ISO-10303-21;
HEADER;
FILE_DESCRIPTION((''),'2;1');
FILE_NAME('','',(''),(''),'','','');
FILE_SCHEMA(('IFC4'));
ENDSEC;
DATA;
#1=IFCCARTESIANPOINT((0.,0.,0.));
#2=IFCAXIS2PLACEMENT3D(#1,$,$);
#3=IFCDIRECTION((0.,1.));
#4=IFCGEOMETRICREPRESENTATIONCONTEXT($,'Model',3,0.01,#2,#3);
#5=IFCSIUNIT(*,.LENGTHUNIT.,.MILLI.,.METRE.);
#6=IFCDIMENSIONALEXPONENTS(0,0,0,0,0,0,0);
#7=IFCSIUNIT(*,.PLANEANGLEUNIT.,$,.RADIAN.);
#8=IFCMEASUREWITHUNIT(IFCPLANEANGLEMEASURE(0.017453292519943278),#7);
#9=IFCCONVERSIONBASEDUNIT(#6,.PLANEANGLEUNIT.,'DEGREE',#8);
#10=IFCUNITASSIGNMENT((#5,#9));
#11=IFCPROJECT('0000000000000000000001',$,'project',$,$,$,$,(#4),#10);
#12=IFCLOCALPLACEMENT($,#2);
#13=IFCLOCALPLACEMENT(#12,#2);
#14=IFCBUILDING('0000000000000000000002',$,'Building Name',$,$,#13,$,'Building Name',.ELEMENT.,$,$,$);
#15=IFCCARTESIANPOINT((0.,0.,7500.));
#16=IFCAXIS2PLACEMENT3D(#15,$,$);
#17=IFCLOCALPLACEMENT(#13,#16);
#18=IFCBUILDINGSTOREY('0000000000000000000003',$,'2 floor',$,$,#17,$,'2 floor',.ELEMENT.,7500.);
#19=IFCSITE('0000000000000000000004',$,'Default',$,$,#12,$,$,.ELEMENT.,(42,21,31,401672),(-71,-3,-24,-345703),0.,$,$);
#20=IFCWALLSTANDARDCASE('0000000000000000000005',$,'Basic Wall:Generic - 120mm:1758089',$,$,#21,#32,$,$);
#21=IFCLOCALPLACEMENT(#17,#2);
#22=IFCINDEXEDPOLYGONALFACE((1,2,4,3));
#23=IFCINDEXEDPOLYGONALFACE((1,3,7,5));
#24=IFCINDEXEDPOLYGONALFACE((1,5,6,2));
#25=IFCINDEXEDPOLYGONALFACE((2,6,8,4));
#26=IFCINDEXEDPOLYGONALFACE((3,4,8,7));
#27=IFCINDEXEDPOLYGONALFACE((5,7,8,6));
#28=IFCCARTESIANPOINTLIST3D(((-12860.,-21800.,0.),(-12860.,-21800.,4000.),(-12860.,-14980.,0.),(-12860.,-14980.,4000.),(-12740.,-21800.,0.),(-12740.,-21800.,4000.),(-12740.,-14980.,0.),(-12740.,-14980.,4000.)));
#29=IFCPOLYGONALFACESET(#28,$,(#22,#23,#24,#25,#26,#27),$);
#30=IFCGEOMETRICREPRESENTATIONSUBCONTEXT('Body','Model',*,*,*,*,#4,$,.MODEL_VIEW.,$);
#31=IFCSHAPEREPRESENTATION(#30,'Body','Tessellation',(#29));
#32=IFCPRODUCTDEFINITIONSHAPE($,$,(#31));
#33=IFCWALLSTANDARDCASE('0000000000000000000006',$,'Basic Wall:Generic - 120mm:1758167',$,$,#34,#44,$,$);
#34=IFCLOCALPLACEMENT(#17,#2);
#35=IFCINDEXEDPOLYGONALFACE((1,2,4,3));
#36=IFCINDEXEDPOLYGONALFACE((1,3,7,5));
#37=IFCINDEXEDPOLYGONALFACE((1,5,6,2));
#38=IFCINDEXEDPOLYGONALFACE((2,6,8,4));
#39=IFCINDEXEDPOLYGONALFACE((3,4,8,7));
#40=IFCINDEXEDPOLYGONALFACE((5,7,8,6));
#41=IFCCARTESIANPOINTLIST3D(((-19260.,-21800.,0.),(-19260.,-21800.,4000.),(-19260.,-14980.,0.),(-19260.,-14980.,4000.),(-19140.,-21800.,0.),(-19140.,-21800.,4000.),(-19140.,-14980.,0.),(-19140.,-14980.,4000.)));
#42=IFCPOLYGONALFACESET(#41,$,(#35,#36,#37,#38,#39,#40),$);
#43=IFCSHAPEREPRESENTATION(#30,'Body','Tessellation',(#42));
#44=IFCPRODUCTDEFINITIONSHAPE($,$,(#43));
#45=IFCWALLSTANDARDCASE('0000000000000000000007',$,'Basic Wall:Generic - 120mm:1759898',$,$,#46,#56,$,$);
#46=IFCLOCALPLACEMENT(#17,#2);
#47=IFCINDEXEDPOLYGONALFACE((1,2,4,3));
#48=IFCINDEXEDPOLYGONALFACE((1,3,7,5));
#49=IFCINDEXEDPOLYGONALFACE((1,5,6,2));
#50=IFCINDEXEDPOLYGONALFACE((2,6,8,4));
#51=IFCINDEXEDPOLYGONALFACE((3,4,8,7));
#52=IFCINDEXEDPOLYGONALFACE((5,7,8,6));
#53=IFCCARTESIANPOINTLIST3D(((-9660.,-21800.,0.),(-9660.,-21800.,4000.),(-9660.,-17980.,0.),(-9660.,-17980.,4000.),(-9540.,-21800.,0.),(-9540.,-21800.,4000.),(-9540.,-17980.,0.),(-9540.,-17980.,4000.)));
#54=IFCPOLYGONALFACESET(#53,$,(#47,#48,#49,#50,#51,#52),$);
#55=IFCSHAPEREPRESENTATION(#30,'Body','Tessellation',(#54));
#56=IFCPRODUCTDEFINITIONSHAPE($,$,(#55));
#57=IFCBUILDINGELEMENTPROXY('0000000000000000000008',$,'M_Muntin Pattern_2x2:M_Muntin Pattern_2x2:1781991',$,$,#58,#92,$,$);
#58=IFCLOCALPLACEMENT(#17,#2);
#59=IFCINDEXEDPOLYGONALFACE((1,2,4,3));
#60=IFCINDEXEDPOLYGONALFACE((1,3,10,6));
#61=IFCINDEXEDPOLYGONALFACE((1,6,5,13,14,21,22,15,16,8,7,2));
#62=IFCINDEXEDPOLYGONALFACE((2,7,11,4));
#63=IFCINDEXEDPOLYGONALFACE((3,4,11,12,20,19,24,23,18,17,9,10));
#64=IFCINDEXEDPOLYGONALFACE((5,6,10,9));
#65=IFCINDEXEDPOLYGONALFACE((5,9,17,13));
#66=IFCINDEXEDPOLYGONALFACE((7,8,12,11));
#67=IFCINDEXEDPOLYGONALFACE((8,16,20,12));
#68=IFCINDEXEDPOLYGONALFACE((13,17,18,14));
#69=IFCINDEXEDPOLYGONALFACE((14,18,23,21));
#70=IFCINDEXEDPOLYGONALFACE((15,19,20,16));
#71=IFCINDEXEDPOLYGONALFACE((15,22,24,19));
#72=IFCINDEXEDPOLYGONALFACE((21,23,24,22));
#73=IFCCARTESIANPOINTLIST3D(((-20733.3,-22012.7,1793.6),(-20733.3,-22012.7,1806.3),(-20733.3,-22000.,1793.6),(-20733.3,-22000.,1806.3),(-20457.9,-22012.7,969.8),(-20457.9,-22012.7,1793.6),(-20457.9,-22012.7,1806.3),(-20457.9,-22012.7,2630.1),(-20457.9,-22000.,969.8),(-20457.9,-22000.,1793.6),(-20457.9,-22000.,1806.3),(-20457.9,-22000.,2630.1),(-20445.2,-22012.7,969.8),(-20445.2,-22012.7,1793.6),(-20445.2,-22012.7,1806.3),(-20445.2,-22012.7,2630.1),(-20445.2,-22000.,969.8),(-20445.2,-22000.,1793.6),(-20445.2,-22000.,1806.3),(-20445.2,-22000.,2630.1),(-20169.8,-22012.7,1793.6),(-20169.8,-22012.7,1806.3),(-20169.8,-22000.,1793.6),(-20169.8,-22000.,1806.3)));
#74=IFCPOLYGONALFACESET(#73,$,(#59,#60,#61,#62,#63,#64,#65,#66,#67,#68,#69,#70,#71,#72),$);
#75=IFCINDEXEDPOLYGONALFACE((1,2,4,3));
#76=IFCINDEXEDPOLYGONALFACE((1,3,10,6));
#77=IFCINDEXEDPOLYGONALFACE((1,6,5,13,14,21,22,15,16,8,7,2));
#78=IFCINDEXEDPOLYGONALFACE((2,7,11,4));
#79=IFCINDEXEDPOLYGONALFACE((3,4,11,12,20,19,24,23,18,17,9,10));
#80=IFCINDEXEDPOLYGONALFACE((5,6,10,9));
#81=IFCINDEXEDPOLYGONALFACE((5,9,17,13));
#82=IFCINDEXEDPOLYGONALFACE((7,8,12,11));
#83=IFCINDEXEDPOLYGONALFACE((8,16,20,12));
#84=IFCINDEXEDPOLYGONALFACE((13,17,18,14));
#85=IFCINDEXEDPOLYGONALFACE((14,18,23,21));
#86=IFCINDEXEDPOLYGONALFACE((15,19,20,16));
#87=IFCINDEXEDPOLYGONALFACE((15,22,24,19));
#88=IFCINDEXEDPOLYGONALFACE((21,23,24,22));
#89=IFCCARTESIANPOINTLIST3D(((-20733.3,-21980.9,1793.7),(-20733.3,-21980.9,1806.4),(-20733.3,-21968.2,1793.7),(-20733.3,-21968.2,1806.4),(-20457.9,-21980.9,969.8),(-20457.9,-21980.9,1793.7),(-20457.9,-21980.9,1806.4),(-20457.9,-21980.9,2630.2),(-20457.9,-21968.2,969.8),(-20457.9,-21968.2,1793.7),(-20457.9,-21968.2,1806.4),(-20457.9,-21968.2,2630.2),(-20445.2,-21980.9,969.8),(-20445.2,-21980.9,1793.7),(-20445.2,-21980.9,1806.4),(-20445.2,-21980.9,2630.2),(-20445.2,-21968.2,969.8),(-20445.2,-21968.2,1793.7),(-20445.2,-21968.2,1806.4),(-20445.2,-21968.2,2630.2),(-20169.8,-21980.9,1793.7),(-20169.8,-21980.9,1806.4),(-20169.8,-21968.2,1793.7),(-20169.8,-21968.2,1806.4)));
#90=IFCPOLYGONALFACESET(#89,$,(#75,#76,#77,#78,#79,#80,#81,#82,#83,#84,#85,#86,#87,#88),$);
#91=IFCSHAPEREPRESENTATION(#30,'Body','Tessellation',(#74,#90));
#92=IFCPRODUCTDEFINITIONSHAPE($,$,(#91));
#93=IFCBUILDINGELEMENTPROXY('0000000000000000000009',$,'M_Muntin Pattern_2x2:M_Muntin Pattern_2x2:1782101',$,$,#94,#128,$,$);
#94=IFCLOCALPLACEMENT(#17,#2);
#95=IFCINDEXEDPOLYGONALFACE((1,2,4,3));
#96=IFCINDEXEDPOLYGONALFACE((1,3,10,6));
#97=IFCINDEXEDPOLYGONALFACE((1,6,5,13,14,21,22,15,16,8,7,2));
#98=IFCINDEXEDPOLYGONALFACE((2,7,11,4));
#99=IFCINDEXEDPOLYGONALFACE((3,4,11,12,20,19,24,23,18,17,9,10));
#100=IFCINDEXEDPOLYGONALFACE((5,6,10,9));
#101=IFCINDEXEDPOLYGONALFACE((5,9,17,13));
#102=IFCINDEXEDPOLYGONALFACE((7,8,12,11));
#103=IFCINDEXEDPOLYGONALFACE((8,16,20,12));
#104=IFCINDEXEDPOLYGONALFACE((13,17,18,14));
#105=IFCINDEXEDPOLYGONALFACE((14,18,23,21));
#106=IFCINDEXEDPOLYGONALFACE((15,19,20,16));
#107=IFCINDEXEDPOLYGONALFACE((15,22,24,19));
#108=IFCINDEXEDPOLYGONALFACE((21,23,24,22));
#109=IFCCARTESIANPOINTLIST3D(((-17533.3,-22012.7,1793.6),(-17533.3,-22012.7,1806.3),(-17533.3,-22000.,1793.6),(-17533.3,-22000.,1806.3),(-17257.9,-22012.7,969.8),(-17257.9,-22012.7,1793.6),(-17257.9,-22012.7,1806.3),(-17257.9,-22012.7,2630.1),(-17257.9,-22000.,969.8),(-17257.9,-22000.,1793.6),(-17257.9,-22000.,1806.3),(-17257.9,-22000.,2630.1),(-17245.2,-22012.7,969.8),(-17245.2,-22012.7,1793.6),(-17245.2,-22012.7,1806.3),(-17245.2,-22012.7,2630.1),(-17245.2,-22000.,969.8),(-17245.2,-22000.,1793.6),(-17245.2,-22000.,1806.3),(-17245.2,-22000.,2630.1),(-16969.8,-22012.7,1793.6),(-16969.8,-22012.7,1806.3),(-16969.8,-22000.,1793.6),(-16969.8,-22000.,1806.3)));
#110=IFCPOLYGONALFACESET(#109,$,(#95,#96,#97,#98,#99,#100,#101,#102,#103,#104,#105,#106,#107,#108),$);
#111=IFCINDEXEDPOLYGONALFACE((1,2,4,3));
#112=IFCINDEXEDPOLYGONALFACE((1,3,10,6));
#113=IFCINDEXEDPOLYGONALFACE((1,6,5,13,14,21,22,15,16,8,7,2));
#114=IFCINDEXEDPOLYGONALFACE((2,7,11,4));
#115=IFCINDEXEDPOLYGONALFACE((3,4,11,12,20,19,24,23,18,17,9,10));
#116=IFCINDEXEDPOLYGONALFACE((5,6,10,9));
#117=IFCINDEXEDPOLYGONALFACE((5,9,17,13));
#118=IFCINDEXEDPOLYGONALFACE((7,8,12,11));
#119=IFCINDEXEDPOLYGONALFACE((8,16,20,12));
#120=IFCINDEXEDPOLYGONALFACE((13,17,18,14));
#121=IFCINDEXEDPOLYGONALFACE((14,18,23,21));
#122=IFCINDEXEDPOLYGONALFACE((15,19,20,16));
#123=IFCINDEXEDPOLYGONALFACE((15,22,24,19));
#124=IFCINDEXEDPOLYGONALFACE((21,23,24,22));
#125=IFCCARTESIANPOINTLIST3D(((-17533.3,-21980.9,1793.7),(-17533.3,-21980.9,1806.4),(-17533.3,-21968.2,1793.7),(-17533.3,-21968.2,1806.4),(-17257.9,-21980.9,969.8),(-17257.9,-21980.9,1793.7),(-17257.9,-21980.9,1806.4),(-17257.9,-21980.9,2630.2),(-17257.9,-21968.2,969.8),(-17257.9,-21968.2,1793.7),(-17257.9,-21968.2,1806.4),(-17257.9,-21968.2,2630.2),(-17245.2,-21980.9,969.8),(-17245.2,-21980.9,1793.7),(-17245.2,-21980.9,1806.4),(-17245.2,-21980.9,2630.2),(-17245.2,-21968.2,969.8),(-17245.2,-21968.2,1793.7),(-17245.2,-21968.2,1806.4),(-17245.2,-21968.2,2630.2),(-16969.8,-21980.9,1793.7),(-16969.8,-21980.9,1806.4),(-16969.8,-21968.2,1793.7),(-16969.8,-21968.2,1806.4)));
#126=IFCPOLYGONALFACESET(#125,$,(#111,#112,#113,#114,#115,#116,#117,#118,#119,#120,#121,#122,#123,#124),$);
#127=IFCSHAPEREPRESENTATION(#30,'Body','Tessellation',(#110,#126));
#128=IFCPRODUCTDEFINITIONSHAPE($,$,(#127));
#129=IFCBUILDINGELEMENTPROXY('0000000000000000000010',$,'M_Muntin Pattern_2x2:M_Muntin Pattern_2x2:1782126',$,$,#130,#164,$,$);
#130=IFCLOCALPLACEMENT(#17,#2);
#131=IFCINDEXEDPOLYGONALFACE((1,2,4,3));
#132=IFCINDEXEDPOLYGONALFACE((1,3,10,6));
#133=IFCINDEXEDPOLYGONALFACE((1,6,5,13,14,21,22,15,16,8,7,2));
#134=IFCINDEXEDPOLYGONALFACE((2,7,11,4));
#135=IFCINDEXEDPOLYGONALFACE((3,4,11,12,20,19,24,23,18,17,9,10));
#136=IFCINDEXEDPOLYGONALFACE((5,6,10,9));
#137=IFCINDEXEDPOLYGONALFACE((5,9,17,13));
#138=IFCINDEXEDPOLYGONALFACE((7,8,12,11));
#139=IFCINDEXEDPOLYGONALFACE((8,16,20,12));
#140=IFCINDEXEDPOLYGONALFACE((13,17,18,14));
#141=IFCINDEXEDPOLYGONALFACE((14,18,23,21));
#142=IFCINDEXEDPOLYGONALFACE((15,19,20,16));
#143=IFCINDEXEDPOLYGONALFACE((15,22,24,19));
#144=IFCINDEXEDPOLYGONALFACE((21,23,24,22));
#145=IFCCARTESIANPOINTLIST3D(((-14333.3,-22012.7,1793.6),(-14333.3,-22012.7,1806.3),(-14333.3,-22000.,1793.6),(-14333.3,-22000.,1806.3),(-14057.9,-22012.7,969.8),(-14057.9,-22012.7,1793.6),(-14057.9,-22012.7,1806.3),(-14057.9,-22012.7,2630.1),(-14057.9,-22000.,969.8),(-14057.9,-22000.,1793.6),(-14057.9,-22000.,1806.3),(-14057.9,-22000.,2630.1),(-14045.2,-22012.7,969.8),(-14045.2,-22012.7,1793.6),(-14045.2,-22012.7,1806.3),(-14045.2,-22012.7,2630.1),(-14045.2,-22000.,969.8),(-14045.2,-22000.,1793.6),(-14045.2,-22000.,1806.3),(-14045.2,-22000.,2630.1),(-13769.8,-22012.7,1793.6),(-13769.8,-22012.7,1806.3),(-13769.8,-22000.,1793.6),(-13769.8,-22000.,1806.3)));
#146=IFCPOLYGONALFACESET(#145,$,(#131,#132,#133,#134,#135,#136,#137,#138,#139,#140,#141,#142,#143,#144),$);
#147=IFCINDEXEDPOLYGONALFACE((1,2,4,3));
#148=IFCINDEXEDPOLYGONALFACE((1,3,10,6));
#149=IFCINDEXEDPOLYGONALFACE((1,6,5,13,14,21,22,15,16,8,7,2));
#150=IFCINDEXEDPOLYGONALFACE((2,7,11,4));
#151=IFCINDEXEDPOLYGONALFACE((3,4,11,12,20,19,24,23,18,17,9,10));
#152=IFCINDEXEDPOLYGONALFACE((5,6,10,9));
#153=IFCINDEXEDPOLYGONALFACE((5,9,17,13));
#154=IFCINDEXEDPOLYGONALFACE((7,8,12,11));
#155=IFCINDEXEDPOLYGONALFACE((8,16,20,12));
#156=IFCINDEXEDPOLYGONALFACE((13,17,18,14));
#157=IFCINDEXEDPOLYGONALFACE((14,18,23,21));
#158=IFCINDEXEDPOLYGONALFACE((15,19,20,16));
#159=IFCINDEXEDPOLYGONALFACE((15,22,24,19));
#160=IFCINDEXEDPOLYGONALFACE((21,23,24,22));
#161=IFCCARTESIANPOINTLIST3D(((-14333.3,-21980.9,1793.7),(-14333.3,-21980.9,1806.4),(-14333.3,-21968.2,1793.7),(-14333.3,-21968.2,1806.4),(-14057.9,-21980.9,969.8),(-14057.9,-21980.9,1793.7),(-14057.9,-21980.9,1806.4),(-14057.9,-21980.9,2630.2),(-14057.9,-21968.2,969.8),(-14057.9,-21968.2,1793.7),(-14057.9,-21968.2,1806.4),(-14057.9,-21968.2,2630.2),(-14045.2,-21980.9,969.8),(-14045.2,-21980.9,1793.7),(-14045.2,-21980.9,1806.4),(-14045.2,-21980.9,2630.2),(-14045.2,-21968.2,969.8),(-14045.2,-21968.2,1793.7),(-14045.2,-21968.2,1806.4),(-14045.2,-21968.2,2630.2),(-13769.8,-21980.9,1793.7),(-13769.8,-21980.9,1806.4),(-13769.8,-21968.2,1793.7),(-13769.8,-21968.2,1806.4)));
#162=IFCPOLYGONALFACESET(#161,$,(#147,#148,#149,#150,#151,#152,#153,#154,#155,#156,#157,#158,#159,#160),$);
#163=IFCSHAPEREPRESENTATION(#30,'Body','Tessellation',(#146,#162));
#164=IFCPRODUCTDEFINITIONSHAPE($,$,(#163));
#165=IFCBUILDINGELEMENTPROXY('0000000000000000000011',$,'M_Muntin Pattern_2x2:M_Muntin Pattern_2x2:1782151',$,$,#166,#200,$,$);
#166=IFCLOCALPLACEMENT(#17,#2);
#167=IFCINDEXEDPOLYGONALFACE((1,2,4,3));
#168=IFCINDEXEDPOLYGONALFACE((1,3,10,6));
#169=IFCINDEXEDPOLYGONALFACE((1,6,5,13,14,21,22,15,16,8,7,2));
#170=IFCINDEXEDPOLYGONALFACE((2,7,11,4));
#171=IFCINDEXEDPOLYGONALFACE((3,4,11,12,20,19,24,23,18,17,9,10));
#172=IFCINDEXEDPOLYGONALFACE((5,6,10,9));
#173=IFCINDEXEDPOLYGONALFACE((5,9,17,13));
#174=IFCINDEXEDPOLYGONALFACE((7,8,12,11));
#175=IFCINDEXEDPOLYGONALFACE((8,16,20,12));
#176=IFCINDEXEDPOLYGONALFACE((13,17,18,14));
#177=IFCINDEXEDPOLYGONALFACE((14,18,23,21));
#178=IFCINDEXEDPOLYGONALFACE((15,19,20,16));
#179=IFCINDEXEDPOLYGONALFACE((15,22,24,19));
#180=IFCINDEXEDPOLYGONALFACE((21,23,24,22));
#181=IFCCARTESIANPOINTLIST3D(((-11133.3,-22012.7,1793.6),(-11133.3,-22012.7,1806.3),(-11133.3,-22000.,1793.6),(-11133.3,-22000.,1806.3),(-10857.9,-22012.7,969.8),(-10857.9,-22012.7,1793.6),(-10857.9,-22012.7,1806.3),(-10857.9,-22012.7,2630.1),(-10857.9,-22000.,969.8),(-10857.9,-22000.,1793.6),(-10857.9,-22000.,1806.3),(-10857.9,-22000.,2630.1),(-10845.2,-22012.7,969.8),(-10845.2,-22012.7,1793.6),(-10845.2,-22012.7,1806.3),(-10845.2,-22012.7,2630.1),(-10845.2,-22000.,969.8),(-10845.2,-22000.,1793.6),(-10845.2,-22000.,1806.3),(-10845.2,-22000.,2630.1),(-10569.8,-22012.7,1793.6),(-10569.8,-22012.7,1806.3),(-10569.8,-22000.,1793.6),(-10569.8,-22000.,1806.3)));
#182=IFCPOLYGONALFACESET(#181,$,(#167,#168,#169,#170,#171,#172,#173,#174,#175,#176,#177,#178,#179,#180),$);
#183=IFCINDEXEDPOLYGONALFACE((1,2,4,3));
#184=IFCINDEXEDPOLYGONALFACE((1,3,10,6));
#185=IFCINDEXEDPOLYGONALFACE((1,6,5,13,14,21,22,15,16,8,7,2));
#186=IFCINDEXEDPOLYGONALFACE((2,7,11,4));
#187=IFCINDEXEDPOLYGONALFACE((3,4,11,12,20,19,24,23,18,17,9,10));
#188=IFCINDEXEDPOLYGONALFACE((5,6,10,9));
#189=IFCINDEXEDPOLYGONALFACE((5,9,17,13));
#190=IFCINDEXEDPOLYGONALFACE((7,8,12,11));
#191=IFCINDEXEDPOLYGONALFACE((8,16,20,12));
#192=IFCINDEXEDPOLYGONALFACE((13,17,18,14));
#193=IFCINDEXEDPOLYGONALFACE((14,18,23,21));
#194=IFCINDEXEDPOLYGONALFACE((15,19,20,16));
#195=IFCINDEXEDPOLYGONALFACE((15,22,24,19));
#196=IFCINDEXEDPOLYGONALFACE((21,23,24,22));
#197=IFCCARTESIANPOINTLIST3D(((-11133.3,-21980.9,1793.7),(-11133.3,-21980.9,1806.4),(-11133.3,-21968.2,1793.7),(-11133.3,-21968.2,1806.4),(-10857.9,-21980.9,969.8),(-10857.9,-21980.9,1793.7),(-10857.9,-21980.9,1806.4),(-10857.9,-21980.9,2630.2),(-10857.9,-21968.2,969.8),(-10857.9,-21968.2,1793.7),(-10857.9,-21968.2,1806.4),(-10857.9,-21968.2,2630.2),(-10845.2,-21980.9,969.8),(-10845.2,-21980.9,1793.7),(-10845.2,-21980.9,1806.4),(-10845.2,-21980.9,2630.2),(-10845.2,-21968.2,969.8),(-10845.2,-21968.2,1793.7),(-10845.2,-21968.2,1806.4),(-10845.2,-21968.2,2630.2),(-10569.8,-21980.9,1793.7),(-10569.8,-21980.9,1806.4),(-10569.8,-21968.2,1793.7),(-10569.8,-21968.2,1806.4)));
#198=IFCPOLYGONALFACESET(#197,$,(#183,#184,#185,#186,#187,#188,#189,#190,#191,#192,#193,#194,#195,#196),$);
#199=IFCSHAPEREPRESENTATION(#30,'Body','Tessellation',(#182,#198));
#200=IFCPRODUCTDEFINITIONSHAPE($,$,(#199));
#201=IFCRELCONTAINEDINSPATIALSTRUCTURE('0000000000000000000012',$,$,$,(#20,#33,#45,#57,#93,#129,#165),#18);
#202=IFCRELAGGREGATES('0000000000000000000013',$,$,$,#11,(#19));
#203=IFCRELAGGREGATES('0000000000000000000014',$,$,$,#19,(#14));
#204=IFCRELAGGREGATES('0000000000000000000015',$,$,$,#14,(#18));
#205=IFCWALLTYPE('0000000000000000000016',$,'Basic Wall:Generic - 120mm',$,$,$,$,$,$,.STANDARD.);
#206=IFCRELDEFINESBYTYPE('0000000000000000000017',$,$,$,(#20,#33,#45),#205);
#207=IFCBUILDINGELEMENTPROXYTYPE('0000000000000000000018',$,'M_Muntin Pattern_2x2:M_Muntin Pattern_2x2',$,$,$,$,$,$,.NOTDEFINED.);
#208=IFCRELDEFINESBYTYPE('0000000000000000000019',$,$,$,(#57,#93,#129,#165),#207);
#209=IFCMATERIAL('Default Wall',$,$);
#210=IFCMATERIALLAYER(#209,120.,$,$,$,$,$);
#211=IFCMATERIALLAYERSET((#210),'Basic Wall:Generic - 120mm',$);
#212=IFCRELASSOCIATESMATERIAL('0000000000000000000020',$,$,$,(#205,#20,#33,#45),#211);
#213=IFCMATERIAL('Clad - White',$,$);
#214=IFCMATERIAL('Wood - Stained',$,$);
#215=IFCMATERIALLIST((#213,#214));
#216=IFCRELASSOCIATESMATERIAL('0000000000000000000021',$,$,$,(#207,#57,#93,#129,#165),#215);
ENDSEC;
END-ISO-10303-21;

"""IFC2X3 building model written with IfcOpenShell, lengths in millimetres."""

from ifc_helpers import new_model, entity, si_unit, converted_unit, direction, frame, frame_2d, origin, place, context, subcontext, project, spatial, polyline, rectangle, outline, extrude, source, transform, mapped, material, material_list, layer, layer_set, layer_usage, type_object, type_shapes, element, save


model = new_model("IFC2X3")

# Units and contexts
model_context = context("Model", 3, precision=0.01, world=origin(), true_north=direction((0.0, 1.0)))
body_context = subcontext(model_context, "Body", "Model", "MODEL_VIEW")
ifc_project = project(units=[si_unit("LENGTHUNIT", "METRE", prefix="MILLI"), converted_unit("PLANEANGLEUNIT", "DEGREE", entity("IfcPlaneAngleMeasure", 0.017453292519943278), si_unit("PLANEANGLEUNIT", "RADIAN"), dimensions=[0, 0, 0, 0, 0, 0, 0])], contexts=[model_context])

# Site, building, storey
site_placement = place(None, origin())
site = spatial("IfcSite", under=ifc_project, at=site_placement, Name="Default", CompositionType="ELEMENT", RefLatitude=(42, 21, 31, 401672), RefLongitude=(-71, -3, -24, -345703), RefElevation=0.0)
building_placement = place(site_placement, origin())
building = spatial("IfcBuilding", under=site, at=building_placement, Name="Building Name", LongName="Building Name", CompositionType="ELEMENT")
storey_placement = place(building_placement, frame((0.0, 0.0, 7500.0)))
storey = spatial("IfcBuildingStorey", under=building, at=storey_placement, Name="2 floor", LongName="2 floor", CompositionType="ELEMENT", Elevation=7500.0)

# Walls
ifc_material_1 = material(Name="Default Wall")
ifc_layer = layer(ifc_material_1, 120.0)
ifc_layer_set = layer_set([ifc_layer], Name="Basic Wall:Generic - 120mm")
ifc_layer_usage_1 = layer_usage(ifc_layer_set, "AXIS2", "NEGATIVE", 60.0)
wall_type = type_object("IfcWallType", Name="Basic Wall:Generic - 120mm", PredefinedType="STANDARD", material=ifc_layer_set)
wall_1_placement = place(storey_placement, frame((-12800.0, -14980.0, 0.0), z_axis=(0.0, 0.0, 1.0), x_axis=(0.0, -1.0, 0.0)))
element("IfcWallStandardCase", 1, at=wall_1_placement, inside=storey, type_object=wall_type, material=ifc_layer_usage_1, Name="Basic Wall:Generic - 120mm:1758089", context=body_context, shape_type="SweptSolid", body=[
    extrude(rectangle(XDim=6820.0, YDim=120.0, at=frame_2d((3410.0, 0.0), x_axis=(-1.0, 0.0))), origin(), (0.0, 0.0, 1.0), 4000.0),
])
ifc_layer_usage_2 = layer_usage(ifc_layer_set, "AXIS2", "NEGATIVE", 60.0)
wall_2_placement = place(storey_placement, frame((-19200.0, -14980.0, 0.0), z_axis=(0.0, 0.0, 1.0), x_axis=(0.0, -1.0, 0.0)))
element("IfcWallStandardCase", 2, at=wall_2_placement, inside=storey, type_object=wall_type, material=ifc_layer_usage_2, Name="Basic Wall:Generic - 120mm:1758167", context=body_context, shape_type="SweptSolid", body=[
    extrude(rectangle(XDim=6820.0, YDim=120.0, at=frame_2d((3410.0, 0.0), x_axis=(-1.0, 0.0))), origin(), (0.0, 0.0, 1.0), 4000.0),
])
ifc_layer_usage_3 = layer_usage(ifc_layer_set, "AXIS2", "NEGATIVE", 60.0)
wall_3_placement = place(storey_placement, frame((-9600.0, -17980.0, 0.0), z_axis=(0.0, 0.0, 1.0), x_axis=(0.0, -1.0, 0.0)))
element("IfcWallStandardCase", 3, at=wall_3_placement, inside=storey, type_object=wall_type, material=ifc_layer_usage_3, Name="Basic Wall:Generic - 120mm:1759898", context=body_context, shape_type="SweptSolid", body=[
    extrude(rectangle(XDim=3820.0, YDim=120.0, at=frame_2d((1910.0, 0.0), x_axis=(-1.0, 0.0))), origin(), (0.0, 0.0, 1.0), 4000.0),
])

# Building element proxies
ifc_material_2 = material(Name="Clad - White")
ifc_material_3 = material(Name="Wood - Stained")
ifc_material_list = material_list([ifc_material_2, ifc_material_3])
building_element_proxy_type_1 = type_object("IfcBuildingElementProxyType", Name="M_Muntin Pattern_2x2:M_Muntin Pattern_2x2", PredefinedType="NOTDEFINED", material=ifc_material_list)
shared_shape_1 = source(origin(), body_context, "Body", "SweptSolid", [
    extrude(outline(polyline([(6.4, -6.4), (830.1, -6.4), (830.1, 6.3), (6.4, 6.3), (6.4, 281.7), (-6.3, 281.7), (-6.3, 6.3), (-830.2, 6.3), (-830.2, -6.4), (-6.3, -6.4), (-6.3, -281.7), (6.4, -281.7), (6.4, -6.4)])), frame((0.0, 9.5, 830.1), z_axis=(0.0, 1.0, 0.0), x_axis=(0.0, 0.0, 1.0)), (0.0, 0.0, 1.0), 12.7),
    extrude(outline(polyline([(6.4, -6.4), (830.2, -6.4), (830.2, 6.3), (6.4, 6.3), (6.4, 281.7), (-6.3, 281.7), (-6.3, 6.3), (-830.2, 6.3), (-830.2, -6.4), (-6.3, -6.4), (-6.3, -281.7), (6.4, -281.7), (6.4, -6.4)])), frame((0.0, -22.2, 830.2), z_axis=(0.0, 1.0, 0.0), x_axis=(0.0, 0.0, 1.0)), (0.0, 0.0, 1.0), 12.7),
])
type_shapes(building_element_proxy_type_1, [shared_shape_1])
for number, where, z_axis, x_axis, name in (
    (4, (-20451.6, -21990.5, 969.8), (0.0, 0.0, 1.0), (-1.0, 0.0, 0.0), "M_Muntin Pattern_2x2:M_Muntin Pattern_2x2:1781991"),
    (5, (-17251.6, -21990.5, 969.8), (0.0, 0.0, 1.0), (-1.0, 0.0, 0.0), "M_Muntin Pattern_2x2:M_Muntin Pattern_2x2:1782101"),
    (6, (-14051.6, -21990.5, 969.8), (0.0, 0.0, 1.0), (-1.0, 0.0, 0.0), "M_Muntin Pattern_2x2:M_Muntin Pattern_2x2:1782126"),
    (7, (-10851.6, -21990.5, 969.8), (0.0, 0.0, 1.0), (-1.0, 0.0, 0.0), "M_Muntin Pattern_2x2:M_Muntin Pattern_2x2:1782151"),
):
    element("IfcBuildingElementProxy", number, at=place(storey_placement, frame(where, z_axis=z_axis, x_axis=x_axis)), inside=storey, type_object=building_element_proxy_type_1, material=ifc_material_list, Name=name, context=body_context, shape_type="MappedRepresentation", body=[
        mapped(shared_shape_1, transform((0.0, 0.0, 0.0), scale=1.0)),
    ])

save(model, "model.ifc")
